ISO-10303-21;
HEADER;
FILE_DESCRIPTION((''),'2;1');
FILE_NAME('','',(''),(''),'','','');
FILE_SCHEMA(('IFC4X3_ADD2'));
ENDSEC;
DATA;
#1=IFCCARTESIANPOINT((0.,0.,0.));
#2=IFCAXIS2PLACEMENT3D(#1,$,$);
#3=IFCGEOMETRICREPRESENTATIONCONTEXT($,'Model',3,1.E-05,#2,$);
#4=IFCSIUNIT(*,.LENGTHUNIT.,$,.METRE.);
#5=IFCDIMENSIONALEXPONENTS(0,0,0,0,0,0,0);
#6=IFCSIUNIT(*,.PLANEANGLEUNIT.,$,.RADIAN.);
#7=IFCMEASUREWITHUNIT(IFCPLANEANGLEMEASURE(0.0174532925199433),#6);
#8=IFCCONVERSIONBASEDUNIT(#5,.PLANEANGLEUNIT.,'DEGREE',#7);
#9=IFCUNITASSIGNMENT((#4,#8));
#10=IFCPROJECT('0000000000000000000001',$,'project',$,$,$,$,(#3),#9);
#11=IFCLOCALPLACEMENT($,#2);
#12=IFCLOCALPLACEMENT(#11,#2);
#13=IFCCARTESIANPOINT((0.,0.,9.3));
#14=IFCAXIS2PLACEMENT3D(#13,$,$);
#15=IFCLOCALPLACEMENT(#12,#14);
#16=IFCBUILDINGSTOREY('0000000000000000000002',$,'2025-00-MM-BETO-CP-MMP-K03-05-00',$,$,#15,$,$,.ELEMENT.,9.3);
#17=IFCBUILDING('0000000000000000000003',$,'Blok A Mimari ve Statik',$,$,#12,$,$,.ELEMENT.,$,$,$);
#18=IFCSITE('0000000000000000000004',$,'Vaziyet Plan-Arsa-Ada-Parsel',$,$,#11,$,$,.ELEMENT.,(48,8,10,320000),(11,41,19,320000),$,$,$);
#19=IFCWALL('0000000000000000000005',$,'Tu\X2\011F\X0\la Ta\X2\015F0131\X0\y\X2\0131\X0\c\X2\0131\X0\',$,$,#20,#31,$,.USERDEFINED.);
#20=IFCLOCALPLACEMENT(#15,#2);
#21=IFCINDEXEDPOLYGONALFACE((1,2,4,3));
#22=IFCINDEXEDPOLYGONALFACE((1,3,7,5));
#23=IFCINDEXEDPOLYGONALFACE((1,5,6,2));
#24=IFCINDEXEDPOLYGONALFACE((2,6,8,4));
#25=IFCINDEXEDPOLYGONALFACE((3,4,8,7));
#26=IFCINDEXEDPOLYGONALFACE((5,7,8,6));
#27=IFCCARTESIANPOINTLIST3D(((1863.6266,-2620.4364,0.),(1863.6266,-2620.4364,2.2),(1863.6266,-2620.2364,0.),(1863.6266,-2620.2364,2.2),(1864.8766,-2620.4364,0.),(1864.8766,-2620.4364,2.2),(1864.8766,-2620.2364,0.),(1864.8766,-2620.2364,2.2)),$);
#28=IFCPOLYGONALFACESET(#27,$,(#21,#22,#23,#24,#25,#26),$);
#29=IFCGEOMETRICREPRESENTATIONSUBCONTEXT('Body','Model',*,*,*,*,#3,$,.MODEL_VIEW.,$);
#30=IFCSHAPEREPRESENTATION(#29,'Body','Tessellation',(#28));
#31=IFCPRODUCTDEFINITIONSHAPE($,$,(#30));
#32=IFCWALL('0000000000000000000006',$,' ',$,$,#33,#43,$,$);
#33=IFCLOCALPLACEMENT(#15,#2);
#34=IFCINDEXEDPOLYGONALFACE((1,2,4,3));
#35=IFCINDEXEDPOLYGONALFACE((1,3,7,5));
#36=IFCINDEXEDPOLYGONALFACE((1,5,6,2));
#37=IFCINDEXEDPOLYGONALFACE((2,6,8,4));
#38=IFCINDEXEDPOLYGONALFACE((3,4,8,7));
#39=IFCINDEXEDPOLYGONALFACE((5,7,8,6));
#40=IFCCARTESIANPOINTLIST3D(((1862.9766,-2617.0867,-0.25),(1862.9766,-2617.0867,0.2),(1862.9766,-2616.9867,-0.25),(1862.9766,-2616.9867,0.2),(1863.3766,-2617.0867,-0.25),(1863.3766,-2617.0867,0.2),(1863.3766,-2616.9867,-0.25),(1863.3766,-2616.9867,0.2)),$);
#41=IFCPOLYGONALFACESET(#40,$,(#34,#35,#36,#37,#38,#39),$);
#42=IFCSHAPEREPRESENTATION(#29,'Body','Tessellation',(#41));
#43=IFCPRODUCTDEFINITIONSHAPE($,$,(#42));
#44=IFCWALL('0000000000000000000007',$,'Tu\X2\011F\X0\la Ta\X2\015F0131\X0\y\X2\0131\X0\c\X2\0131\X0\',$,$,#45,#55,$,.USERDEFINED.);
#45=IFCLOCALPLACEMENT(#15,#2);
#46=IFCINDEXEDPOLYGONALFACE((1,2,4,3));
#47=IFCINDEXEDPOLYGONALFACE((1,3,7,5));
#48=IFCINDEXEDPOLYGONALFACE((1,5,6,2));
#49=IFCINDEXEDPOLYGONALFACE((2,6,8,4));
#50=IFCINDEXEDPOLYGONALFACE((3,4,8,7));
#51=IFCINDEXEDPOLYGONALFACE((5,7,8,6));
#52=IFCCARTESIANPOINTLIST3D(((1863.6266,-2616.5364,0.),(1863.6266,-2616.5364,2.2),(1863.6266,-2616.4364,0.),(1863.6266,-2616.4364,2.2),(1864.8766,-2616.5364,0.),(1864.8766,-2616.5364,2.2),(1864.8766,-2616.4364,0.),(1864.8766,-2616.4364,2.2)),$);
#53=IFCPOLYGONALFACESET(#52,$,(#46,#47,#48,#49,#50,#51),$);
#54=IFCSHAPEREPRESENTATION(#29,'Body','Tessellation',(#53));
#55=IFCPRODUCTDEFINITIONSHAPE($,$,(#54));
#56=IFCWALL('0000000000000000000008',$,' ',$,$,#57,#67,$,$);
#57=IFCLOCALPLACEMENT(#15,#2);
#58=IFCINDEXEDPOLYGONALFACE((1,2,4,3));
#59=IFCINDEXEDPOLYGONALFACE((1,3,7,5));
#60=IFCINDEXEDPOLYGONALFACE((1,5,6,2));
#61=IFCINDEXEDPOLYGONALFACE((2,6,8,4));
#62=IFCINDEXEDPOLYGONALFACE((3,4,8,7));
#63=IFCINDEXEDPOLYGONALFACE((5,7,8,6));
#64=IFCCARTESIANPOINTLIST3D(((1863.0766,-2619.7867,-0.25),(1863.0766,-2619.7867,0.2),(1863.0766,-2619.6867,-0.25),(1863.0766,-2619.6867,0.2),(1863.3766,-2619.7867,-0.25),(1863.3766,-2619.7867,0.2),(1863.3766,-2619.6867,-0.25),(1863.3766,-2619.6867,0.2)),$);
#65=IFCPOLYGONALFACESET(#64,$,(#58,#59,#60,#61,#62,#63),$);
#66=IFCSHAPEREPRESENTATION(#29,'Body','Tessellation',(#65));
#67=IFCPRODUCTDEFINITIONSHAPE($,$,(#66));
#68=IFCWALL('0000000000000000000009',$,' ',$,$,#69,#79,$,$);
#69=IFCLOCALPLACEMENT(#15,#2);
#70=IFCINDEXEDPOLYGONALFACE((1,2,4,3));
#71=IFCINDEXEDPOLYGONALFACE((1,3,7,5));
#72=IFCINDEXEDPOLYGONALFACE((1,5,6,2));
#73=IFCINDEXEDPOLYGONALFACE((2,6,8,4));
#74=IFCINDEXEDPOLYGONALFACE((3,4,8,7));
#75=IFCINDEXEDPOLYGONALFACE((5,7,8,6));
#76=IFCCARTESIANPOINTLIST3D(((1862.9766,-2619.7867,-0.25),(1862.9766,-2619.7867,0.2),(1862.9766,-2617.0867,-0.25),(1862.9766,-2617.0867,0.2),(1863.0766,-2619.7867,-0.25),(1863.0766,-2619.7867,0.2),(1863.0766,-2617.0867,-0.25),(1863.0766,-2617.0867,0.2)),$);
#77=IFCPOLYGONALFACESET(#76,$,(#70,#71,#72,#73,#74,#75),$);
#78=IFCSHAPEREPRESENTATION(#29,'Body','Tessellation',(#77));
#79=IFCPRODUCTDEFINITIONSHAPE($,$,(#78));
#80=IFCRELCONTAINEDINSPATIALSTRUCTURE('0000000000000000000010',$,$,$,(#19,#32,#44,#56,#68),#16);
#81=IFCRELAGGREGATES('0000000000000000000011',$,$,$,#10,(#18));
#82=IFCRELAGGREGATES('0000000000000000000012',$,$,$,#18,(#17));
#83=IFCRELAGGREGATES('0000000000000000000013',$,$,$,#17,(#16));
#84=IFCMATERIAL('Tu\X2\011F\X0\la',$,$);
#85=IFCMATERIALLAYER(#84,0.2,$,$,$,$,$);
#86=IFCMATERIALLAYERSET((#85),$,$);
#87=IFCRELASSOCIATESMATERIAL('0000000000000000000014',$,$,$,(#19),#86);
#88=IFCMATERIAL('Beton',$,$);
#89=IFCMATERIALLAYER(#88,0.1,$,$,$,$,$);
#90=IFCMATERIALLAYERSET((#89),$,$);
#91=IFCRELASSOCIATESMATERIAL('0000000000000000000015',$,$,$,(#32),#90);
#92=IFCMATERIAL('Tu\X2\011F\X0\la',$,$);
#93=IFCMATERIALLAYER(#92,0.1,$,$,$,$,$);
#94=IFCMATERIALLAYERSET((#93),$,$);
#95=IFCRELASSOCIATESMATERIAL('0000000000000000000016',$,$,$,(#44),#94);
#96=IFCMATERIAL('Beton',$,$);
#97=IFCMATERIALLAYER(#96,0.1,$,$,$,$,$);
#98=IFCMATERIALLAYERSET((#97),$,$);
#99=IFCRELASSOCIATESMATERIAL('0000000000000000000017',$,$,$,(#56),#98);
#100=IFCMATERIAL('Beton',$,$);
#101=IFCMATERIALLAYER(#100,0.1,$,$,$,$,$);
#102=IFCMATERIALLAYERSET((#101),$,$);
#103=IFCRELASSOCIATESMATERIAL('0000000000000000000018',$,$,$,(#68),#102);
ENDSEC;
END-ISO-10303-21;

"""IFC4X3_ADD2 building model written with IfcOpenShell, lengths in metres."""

from ifc_helpers import new_model, entity, si_unit, converted_unit, frame, frame_2d, origin, origin_with_axes, place, context, subcontext, project, spatial, rectangle, extrude, material, layer, layer_set, layer_usage, element, save


model = new_model("IFC4X3_ADD2")

# Units and contexts
model_context = context("Model", 3, precision=1e-05, world=origin())
body_context = subcontext(model_context, "Body", "Model", "MODEL_VIEW")
ifc_project = project(units=[si_unit("LENGTHUNIT", "METRE"), converted_unit("PLANEANGLEUNIT", "DEGREE", entity("IfcPlaneAngleMeasure", 0.0174532925199433), si_unit("PLANEANGLEUNIT", "RADIAN"), dimensions=[0, 0, 0, 0, 0, 0, 0])], contexts=[model_context])

# Site, building, storey
site_placement = place(None, origin())
site = spatial("IfcSite", under=ifc_project, at=site_placement, Name="Vaziyet Plan-Arsa-Ada-Parsel", CompositionType="ELEMENT", RefLatitude=(48, 8, 10, 320000), RefLongitude=(11, 41, 19, 320000))
building_placement = place(site_placement, origin())
building = spatial("IfcBuilding", under=site, at=building_placement, Name="Blok A Mimari ve Statik", CompositionType="ELEMENT")
storey_placement = place(building_placement, frame((0.0, 0.0, 9.3)))
storey = spatial("IfcBuildingStorey", under=building, at=storey_placement, Name="2025-00-MM-BETO-CP-MMP-K03-05-00", CompositionType="ELEMENT", Elevation=9.3)

# Walls
ifc_material_1 = material(Name="Tuğla")
ifc_layer_1 = layer(ifc_material_1, 0.2)
ifc_layer_set_1 = layer_set([ifc_layer_1])
ifc_layer_usage_1 = layer_usage(ifc_layer_set_1, "AXIS2", "POSITIVE", 0.0)
wall_1_placement = place(storey_placement, frame((1864.8766, -2620.2364, 0.0), z_axis=(0.0, 0.0, 1.0), x_axis=(-1.0, 0.0, 0.0)))
element("IfcWall", 1, at=wall_1_placement, inside=storey, material=ifc_layer_usage_1, Name="Tuğla Taşıyıcı", PredefinedType="USERDEFINED", context=body_context, shape_type="SweptSolid", body=[
    extrude(rectangle(XDim=1.25, YDim=0.2, at=frame_2d((0.625, 0.1), x_axis=(1.0, 0.0))), origin_with_axes(), (0.0, 0.0, 1.0), 2.2),
])
ifc_material_2 = material(Name="Beton")
ifc_layer_2 = layer(ifc_material_2, 0.1)
ifc_layer_set_2 = layer_set([ifc_layer_2])
ifc_layer_usage_2 = layer_usage(ifc_layer_set_2, "AXIS2", "POSITIVE", 0.0)
wall_2_placement = place(storey_placement, frame((1863.3766, -2616.9867, -0.25), z_axis=(0.0, 0.0, 1.0), x_axis=(-1.0, 0.0, 0.0)))
element("IfcWall", 2, at=wall_2_placement, inside=storey, material=ifc_layer_usage_2, Name=" ", context=body_context, shape_type="SweptSolid", body=[
    extrude(rectangle(XDim=0.4, YDim=0.1, at=frame_2d((0.2, 0.05), x_axis=(1.0, 0.0))), origin_with_axes(), (0.0, 0.0, 1.0), 0.45),
])
ifc_material_3 = material(Name="Tuğla")
ifc_layer_3 = layer(ifc_material_3, 0.1)
ifc_layer_set_3 = layer_set([ifc_layer_3])
ifc_layer_usage_3 = layer_usage(ifc_layer_set_3, "AXIS2", "POSITIVE", 0.0)
wall_3_placement = place(storey_placement, frame((1864.8766, -2616.4364, 0.0), z_axis=(0.0, 0.0, 1.0), x_axis=(-1.0, 0.000002, 0.0)))
element("IfcWall", 3, at=wall_3_placement, inside=storey, material=ifc_layer_usage_3, Name="Tuğla Taşıyıcı", PredefinedType="USERDEFINED", context=body_context, shape_type="SweptSolid", body=[
    extrude(rectangle(XDim=1.25, YDim=0.1, at=frame_2d((0.625, 0.05), x_axis=(1.0, 0.0))), origin_with_axes(), (0.0, 0.0, 1.0), 2.2),
])
ifc_material_4 = material(Name="Beton")
ifc_layer_4 = layer(ifc_material_4, 0.1)
ifc_layer_set_4 = layer_set([ifc_layer_4])
ifc_layer_usage_4 = layer_usage(ifc_layer_set_4, "AXIS2", "POSITIVE", 0.0)
wall_4_placement = place(storey_placement, frame((1863.0766, -2619.7867, -0.25)))
element("IfcWall", 4, at=wall_4_placement, inside=storey, material=ifc_layer_usage_4, Name=" ", context=body_context, shape_type="SweptSolid", body=[
    extrude(rectangle(XDim=0.3, YDim=0.1, at=frame_2d((0.15, 0.05), x_axis=(1.0, 0.0))), origin_with_axes(), (0.0, 0.0, 1.0), 0.45),
])
ifc_material_5 = material(Name="Beton")
ifc_layer_5 = layer(ifc_material_5, 0.1)
ifc_layer_set_5 = layer_set([ifc_layer_5])
ifc_layer_usage_5 = layer_usage(ifc_layer_set_5, "AXIS2", "POSITIVE", 0.0)
wall_5_placement = place(storey_placement, frame((1862.9766, -2617.0867, -0.25), z_axis=(0.0, 0.0, 1.0), x_axis=(0.0, -1.0, 0.0)))
element("IfcWall", 5, at=wall_5_placement, inside=storey, material=ifc_layer_usage_5, Name=" ", context=body_context, shape_type="SweptSolid", body=[
    extrude(rectangle(XDim=2.7, YDim=0.1, at=frame_2d((1.35, 0.05), x_axis=(1.0, 0.0))), origin_with_axes(), (0.0, 0.0, 1.0), 0.45),
])

save(model, "model.ifc")
